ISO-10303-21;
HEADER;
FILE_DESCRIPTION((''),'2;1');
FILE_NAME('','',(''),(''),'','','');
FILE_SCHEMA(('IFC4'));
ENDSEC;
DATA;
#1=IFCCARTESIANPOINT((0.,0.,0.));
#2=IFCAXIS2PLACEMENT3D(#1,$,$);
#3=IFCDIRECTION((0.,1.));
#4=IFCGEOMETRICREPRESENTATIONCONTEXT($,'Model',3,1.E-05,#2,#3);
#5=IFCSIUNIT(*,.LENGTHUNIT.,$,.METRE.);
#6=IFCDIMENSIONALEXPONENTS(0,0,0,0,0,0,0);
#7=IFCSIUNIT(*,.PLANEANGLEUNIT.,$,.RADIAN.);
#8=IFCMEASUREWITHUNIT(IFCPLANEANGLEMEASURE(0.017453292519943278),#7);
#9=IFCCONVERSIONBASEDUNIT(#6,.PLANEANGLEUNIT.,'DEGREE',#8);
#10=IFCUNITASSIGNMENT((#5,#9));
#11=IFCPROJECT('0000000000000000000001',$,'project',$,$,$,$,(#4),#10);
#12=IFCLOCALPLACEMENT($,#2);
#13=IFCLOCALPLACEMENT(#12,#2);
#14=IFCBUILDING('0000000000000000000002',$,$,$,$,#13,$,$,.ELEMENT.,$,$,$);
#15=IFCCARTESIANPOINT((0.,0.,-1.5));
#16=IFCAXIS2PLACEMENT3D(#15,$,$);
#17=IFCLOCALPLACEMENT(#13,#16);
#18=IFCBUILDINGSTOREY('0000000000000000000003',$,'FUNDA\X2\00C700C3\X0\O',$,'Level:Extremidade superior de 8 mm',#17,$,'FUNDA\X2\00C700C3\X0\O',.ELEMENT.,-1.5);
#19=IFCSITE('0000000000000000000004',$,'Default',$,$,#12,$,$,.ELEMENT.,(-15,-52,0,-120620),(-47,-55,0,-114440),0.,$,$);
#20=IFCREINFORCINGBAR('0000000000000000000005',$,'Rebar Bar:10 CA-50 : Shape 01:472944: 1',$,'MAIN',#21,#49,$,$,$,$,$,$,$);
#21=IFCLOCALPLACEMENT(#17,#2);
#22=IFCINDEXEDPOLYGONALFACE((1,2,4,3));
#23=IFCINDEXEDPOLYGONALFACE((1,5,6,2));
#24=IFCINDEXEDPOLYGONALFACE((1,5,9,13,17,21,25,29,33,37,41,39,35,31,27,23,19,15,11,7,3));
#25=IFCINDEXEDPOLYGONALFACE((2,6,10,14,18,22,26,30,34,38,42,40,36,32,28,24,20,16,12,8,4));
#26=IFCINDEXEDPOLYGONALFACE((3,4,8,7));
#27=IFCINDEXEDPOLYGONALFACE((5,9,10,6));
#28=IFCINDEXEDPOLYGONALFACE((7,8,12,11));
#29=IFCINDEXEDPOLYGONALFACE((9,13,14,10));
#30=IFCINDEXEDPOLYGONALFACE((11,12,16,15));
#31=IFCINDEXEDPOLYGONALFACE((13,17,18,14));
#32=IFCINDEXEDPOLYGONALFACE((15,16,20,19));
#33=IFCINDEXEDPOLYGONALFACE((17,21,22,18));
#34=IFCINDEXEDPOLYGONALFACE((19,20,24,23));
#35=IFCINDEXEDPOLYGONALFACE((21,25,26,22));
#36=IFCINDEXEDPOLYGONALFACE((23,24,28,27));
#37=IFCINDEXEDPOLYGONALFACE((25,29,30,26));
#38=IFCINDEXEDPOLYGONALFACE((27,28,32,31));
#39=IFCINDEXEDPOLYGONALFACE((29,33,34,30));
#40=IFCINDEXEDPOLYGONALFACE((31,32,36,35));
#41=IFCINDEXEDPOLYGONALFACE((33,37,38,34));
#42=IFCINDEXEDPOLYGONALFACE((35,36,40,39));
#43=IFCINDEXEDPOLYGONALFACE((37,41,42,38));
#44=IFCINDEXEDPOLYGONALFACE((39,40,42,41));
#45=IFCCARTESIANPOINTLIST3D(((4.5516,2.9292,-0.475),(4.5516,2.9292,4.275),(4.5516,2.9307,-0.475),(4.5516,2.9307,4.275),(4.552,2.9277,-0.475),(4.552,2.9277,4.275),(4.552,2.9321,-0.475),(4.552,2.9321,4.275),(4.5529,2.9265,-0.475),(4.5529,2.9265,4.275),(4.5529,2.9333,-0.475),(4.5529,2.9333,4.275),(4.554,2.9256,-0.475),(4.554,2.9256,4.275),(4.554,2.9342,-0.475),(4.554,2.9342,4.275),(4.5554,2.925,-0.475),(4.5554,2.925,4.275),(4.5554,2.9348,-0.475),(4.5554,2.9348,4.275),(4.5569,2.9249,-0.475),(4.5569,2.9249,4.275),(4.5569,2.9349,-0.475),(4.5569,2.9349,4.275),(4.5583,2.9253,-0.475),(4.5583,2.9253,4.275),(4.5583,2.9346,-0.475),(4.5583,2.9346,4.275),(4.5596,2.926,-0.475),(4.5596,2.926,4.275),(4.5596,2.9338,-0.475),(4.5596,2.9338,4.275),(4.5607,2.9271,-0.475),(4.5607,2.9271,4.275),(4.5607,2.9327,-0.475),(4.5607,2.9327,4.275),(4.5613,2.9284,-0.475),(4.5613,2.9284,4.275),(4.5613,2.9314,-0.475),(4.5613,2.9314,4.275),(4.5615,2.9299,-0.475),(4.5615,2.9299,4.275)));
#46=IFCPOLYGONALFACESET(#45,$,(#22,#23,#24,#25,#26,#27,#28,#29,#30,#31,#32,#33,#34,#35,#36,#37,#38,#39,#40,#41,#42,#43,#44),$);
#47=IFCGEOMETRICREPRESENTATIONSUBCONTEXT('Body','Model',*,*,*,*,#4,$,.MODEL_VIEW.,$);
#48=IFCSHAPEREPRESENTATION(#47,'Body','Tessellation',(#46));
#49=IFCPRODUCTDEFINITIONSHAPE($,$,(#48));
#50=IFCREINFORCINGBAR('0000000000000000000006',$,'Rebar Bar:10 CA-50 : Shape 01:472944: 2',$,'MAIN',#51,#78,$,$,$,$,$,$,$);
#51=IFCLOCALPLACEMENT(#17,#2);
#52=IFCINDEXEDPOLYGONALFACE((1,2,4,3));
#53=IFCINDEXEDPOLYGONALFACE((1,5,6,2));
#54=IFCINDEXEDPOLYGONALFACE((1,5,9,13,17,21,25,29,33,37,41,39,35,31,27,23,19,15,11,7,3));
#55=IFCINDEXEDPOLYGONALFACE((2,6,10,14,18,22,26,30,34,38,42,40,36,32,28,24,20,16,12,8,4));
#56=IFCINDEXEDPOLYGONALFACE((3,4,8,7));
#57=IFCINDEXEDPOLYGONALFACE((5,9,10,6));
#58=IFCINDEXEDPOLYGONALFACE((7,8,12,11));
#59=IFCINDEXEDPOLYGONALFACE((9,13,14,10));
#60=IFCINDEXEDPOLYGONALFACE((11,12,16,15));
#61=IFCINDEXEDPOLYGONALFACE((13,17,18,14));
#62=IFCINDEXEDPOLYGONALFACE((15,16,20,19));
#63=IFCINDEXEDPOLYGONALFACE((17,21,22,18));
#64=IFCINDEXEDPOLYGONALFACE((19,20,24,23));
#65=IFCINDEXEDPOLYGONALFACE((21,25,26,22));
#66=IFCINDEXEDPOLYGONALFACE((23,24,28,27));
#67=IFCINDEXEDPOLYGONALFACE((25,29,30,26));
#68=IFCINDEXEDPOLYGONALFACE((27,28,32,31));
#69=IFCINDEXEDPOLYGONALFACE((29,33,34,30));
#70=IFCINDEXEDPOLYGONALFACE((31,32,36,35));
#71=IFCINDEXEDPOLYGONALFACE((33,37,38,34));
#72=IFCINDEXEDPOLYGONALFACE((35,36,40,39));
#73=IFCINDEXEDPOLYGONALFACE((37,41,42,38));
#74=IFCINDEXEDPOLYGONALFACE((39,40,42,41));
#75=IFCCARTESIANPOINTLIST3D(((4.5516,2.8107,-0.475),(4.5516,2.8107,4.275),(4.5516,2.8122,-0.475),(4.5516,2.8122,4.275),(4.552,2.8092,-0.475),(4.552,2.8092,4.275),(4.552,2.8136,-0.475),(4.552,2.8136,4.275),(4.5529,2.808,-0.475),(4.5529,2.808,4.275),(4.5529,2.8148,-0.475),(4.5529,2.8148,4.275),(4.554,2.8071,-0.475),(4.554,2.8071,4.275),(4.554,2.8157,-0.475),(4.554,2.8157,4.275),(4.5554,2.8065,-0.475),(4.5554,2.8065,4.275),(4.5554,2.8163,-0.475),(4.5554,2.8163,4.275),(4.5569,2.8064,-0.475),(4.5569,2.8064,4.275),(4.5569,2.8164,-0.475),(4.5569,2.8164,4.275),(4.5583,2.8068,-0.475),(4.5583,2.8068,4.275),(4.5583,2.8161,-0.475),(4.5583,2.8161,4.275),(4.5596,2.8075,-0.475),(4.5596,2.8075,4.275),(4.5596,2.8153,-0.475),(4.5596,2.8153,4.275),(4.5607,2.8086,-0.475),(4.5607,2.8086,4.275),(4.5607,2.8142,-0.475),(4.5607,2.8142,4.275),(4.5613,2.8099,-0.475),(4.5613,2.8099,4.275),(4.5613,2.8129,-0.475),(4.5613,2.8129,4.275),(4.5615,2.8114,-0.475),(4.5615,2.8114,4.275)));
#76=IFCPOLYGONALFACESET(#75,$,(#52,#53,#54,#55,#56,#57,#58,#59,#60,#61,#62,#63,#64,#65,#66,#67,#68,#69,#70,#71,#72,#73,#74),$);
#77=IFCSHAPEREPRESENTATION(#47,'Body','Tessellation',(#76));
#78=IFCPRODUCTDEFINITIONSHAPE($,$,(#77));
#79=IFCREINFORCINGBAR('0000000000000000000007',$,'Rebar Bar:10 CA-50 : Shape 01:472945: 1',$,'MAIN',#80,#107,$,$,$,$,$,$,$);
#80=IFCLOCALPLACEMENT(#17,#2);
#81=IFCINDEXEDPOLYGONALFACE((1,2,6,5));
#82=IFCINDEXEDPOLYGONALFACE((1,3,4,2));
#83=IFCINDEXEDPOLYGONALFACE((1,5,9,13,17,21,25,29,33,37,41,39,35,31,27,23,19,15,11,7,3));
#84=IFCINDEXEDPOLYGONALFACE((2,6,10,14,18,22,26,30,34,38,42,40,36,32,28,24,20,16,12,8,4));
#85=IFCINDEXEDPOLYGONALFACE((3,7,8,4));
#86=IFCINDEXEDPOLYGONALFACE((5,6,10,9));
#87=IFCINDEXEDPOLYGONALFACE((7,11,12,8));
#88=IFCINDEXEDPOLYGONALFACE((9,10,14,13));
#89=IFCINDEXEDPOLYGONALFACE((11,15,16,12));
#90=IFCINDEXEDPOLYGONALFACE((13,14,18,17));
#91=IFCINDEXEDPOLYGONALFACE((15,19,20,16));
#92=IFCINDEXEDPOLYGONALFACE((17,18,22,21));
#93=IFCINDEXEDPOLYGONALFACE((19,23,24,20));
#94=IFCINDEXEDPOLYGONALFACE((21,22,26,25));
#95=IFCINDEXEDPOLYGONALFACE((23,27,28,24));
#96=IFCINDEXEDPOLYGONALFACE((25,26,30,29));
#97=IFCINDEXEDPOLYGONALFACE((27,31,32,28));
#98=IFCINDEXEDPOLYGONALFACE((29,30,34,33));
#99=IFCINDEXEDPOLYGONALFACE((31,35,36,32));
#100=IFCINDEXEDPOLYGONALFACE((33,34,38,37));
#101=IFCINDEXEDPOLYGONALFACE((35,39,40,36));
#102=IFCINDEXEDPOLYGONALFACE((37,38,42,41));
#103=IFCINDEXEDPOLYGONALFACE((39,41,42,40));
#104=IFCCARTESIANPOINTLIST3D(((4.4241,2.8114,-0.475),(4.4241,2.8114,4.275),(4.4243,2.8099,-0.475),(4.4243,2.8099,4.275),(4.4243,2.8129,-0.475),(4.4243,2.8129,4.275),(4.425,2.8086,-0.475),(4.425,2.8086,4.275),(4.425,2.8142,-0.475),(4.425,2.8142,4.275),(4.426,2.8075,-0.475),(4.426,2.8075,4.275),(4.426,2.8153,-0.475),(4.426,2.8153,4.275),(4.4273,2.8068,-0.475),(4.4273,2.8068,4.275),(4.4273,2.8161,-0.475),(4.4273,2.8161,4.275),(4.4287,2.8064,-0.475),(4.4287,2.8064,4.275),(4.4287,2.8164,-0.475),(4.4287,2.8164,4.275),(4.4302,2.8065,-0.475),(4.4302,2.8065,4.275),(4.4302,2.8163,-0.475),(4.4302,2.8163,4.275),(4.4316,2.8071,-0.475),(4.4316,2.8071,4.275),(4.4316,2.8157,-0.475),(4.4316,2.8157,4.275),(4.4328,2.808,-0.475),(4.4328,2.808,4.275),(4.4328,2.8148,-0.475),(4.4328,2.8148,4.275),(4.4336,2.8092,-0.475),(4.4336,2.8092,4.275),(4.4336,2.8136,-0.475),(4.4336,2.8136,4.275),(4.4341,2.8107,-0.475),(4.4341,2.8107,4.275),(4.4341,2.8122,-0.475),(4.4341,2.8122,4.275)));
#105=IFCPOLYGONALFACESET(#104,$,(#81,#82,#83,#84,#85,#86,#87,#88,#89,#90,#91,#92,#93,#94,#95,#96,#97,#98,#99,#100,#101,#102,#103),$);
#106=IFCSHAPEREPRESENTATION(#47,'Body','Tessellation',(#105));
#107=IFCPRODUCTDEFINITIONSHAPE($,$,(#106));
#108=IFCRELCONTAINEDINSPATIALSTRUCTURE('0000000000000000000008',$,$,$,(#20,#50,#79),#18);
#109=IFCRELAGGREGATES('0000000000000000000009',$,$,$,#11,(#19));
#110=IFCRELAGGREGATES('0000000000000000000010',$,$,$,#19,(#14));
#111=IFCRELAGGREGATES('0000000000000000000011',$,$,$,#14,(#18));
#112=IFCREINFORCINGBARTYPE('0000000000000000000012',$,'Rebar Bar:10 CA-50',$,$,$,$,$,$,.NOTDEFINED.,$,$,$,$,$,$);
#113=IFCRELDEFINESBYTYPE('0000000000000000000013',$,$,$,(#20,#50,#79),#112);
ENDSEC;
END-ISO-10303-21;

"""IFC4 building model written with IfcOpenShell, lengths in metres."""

from ifc_helpers import new_model, entity, si_unit, converted_unit, direction, frame, origin, place, context, subcontext, project, spatial, type_object, element, save


model = new_model("IFC4")

# Units and contexts
model_context = context("Model", 3, precision=1e-05, world=origin(), true_north=direction((0.0, 1.0)))
body_context = subcontext(model_context, "Body", "Model", "MODEL_VIEW")
ifc_project = project(units=[si_unit("LENGTHUNIT", "METRE"), converted_unit("PLANEANGLEUNIT", "DEGREE", entity("IfcPlaneAngleMeasure", 0.017453292519943278), si_unit("PLANEANGLEUNIT", "RADIAN"), dimensions=[0, 0, 0, 0, 0, 0, 0])], contexts=[model_context])

# Site, building, storey
site_placement = place(None, origin())
site = spatial("IfcSite", under=ifc_project, at=site_placement, Name="Default", CompositionType="ELEMENT", RefLatitude=(-15, -52, 0, -120620), RefLongitude=(-47, -55, 0, -114440), RefElevation=0.0)
building_placement = place(site_placement, origin())
building = spatial("IfcBuilding", under=site, at=building_placement, CompositionType="ELEMENT")
storey_placement = place(building_placement, frame((0.0, 0.0, -1.5)))
storey = spatial("IfcBuildingStorey", under=building, at=storey_placement, Name="FUNDAÇÃO", ObjectType="Level:Extremidade superior de 8 mm", LongName="FUNDAÇÃO", CompositionType="ELEMENT", Elevation=-1.5)

# Reinforcing bars
reinforcing_bar_type_1 = type_object("IfcReinforcingBarType", Name="Rebar Bar:10 CA-50", PredefinedType="NOTDEFINED")
reinforcing_bar_1_placement = place(storey_placement, origin())
element("IfcReinforcingBar", 1, at=reinforcing_bar_1_placement, inside=storey, type_object=reinforcing_bar_type_1, Name="Rebar Bar:10 CA-50 : Shape 01:472944: 1", ObjectType="MAIN", context=body_context, shape_type="AdvancedSweptSolid", body=[
    entity("IfcSweptDiskSolid", entity("IfcIndexedPolyCurve", entity("IfcCartesianPointList3D", [[4.5565, 2.9299, -0.475], [4.5565, 2.9299, 4.275]]), None, False), 0.005, None, 0.0, 1.0),
])
reinforcing_bar_2_placement = place(storey_placement, origin())
element("IfcReinforcingBar", 2, at=reinforcing_bar_2_placement, inside=storey, type_object=reinforcing_bar_type_1, Name="Rebar Bar:10 CA-50 : Shape 01:472944: 2", ObjectType="MAIN", context=body_context, shape_type="AdvancedSweptSolid", body=[
    entity("IfcSweptDiskSolid", entity("IfcIndexedPolyCurve", entity("IfcCartesianPointList3D", [[4.5565, 2.8114, -0.475], [4.5565, 2.8114, 4.275]]), None, False), 0.005, None, 0.0, 1.0),
])
reinforcing_bar_3_placement = place(storey_placement, origin())
element("IfcReinforcingBar", 3, at=reinforcing_bar_3_placement, inside=storey, type_object=reinforcing_bar_type_1, Name="Rebar Bar:10 CA-50 : Shape 01:472945: 1", ObjectType="MAIN", context=body_context, shape_type="AdvancedSweptSolid", body=[
    entity("IfcSweptDiskSolid", entity("IfcIndexedPolyCurve", entity("IfcCartesianPointList3D", [[4.4291, 2.8114, 4.275], [4.4291, 2.8114, -0.475]]), None, False), 0.005, None, 0.0, 1.0),
])

save(model, "model.ifc")
